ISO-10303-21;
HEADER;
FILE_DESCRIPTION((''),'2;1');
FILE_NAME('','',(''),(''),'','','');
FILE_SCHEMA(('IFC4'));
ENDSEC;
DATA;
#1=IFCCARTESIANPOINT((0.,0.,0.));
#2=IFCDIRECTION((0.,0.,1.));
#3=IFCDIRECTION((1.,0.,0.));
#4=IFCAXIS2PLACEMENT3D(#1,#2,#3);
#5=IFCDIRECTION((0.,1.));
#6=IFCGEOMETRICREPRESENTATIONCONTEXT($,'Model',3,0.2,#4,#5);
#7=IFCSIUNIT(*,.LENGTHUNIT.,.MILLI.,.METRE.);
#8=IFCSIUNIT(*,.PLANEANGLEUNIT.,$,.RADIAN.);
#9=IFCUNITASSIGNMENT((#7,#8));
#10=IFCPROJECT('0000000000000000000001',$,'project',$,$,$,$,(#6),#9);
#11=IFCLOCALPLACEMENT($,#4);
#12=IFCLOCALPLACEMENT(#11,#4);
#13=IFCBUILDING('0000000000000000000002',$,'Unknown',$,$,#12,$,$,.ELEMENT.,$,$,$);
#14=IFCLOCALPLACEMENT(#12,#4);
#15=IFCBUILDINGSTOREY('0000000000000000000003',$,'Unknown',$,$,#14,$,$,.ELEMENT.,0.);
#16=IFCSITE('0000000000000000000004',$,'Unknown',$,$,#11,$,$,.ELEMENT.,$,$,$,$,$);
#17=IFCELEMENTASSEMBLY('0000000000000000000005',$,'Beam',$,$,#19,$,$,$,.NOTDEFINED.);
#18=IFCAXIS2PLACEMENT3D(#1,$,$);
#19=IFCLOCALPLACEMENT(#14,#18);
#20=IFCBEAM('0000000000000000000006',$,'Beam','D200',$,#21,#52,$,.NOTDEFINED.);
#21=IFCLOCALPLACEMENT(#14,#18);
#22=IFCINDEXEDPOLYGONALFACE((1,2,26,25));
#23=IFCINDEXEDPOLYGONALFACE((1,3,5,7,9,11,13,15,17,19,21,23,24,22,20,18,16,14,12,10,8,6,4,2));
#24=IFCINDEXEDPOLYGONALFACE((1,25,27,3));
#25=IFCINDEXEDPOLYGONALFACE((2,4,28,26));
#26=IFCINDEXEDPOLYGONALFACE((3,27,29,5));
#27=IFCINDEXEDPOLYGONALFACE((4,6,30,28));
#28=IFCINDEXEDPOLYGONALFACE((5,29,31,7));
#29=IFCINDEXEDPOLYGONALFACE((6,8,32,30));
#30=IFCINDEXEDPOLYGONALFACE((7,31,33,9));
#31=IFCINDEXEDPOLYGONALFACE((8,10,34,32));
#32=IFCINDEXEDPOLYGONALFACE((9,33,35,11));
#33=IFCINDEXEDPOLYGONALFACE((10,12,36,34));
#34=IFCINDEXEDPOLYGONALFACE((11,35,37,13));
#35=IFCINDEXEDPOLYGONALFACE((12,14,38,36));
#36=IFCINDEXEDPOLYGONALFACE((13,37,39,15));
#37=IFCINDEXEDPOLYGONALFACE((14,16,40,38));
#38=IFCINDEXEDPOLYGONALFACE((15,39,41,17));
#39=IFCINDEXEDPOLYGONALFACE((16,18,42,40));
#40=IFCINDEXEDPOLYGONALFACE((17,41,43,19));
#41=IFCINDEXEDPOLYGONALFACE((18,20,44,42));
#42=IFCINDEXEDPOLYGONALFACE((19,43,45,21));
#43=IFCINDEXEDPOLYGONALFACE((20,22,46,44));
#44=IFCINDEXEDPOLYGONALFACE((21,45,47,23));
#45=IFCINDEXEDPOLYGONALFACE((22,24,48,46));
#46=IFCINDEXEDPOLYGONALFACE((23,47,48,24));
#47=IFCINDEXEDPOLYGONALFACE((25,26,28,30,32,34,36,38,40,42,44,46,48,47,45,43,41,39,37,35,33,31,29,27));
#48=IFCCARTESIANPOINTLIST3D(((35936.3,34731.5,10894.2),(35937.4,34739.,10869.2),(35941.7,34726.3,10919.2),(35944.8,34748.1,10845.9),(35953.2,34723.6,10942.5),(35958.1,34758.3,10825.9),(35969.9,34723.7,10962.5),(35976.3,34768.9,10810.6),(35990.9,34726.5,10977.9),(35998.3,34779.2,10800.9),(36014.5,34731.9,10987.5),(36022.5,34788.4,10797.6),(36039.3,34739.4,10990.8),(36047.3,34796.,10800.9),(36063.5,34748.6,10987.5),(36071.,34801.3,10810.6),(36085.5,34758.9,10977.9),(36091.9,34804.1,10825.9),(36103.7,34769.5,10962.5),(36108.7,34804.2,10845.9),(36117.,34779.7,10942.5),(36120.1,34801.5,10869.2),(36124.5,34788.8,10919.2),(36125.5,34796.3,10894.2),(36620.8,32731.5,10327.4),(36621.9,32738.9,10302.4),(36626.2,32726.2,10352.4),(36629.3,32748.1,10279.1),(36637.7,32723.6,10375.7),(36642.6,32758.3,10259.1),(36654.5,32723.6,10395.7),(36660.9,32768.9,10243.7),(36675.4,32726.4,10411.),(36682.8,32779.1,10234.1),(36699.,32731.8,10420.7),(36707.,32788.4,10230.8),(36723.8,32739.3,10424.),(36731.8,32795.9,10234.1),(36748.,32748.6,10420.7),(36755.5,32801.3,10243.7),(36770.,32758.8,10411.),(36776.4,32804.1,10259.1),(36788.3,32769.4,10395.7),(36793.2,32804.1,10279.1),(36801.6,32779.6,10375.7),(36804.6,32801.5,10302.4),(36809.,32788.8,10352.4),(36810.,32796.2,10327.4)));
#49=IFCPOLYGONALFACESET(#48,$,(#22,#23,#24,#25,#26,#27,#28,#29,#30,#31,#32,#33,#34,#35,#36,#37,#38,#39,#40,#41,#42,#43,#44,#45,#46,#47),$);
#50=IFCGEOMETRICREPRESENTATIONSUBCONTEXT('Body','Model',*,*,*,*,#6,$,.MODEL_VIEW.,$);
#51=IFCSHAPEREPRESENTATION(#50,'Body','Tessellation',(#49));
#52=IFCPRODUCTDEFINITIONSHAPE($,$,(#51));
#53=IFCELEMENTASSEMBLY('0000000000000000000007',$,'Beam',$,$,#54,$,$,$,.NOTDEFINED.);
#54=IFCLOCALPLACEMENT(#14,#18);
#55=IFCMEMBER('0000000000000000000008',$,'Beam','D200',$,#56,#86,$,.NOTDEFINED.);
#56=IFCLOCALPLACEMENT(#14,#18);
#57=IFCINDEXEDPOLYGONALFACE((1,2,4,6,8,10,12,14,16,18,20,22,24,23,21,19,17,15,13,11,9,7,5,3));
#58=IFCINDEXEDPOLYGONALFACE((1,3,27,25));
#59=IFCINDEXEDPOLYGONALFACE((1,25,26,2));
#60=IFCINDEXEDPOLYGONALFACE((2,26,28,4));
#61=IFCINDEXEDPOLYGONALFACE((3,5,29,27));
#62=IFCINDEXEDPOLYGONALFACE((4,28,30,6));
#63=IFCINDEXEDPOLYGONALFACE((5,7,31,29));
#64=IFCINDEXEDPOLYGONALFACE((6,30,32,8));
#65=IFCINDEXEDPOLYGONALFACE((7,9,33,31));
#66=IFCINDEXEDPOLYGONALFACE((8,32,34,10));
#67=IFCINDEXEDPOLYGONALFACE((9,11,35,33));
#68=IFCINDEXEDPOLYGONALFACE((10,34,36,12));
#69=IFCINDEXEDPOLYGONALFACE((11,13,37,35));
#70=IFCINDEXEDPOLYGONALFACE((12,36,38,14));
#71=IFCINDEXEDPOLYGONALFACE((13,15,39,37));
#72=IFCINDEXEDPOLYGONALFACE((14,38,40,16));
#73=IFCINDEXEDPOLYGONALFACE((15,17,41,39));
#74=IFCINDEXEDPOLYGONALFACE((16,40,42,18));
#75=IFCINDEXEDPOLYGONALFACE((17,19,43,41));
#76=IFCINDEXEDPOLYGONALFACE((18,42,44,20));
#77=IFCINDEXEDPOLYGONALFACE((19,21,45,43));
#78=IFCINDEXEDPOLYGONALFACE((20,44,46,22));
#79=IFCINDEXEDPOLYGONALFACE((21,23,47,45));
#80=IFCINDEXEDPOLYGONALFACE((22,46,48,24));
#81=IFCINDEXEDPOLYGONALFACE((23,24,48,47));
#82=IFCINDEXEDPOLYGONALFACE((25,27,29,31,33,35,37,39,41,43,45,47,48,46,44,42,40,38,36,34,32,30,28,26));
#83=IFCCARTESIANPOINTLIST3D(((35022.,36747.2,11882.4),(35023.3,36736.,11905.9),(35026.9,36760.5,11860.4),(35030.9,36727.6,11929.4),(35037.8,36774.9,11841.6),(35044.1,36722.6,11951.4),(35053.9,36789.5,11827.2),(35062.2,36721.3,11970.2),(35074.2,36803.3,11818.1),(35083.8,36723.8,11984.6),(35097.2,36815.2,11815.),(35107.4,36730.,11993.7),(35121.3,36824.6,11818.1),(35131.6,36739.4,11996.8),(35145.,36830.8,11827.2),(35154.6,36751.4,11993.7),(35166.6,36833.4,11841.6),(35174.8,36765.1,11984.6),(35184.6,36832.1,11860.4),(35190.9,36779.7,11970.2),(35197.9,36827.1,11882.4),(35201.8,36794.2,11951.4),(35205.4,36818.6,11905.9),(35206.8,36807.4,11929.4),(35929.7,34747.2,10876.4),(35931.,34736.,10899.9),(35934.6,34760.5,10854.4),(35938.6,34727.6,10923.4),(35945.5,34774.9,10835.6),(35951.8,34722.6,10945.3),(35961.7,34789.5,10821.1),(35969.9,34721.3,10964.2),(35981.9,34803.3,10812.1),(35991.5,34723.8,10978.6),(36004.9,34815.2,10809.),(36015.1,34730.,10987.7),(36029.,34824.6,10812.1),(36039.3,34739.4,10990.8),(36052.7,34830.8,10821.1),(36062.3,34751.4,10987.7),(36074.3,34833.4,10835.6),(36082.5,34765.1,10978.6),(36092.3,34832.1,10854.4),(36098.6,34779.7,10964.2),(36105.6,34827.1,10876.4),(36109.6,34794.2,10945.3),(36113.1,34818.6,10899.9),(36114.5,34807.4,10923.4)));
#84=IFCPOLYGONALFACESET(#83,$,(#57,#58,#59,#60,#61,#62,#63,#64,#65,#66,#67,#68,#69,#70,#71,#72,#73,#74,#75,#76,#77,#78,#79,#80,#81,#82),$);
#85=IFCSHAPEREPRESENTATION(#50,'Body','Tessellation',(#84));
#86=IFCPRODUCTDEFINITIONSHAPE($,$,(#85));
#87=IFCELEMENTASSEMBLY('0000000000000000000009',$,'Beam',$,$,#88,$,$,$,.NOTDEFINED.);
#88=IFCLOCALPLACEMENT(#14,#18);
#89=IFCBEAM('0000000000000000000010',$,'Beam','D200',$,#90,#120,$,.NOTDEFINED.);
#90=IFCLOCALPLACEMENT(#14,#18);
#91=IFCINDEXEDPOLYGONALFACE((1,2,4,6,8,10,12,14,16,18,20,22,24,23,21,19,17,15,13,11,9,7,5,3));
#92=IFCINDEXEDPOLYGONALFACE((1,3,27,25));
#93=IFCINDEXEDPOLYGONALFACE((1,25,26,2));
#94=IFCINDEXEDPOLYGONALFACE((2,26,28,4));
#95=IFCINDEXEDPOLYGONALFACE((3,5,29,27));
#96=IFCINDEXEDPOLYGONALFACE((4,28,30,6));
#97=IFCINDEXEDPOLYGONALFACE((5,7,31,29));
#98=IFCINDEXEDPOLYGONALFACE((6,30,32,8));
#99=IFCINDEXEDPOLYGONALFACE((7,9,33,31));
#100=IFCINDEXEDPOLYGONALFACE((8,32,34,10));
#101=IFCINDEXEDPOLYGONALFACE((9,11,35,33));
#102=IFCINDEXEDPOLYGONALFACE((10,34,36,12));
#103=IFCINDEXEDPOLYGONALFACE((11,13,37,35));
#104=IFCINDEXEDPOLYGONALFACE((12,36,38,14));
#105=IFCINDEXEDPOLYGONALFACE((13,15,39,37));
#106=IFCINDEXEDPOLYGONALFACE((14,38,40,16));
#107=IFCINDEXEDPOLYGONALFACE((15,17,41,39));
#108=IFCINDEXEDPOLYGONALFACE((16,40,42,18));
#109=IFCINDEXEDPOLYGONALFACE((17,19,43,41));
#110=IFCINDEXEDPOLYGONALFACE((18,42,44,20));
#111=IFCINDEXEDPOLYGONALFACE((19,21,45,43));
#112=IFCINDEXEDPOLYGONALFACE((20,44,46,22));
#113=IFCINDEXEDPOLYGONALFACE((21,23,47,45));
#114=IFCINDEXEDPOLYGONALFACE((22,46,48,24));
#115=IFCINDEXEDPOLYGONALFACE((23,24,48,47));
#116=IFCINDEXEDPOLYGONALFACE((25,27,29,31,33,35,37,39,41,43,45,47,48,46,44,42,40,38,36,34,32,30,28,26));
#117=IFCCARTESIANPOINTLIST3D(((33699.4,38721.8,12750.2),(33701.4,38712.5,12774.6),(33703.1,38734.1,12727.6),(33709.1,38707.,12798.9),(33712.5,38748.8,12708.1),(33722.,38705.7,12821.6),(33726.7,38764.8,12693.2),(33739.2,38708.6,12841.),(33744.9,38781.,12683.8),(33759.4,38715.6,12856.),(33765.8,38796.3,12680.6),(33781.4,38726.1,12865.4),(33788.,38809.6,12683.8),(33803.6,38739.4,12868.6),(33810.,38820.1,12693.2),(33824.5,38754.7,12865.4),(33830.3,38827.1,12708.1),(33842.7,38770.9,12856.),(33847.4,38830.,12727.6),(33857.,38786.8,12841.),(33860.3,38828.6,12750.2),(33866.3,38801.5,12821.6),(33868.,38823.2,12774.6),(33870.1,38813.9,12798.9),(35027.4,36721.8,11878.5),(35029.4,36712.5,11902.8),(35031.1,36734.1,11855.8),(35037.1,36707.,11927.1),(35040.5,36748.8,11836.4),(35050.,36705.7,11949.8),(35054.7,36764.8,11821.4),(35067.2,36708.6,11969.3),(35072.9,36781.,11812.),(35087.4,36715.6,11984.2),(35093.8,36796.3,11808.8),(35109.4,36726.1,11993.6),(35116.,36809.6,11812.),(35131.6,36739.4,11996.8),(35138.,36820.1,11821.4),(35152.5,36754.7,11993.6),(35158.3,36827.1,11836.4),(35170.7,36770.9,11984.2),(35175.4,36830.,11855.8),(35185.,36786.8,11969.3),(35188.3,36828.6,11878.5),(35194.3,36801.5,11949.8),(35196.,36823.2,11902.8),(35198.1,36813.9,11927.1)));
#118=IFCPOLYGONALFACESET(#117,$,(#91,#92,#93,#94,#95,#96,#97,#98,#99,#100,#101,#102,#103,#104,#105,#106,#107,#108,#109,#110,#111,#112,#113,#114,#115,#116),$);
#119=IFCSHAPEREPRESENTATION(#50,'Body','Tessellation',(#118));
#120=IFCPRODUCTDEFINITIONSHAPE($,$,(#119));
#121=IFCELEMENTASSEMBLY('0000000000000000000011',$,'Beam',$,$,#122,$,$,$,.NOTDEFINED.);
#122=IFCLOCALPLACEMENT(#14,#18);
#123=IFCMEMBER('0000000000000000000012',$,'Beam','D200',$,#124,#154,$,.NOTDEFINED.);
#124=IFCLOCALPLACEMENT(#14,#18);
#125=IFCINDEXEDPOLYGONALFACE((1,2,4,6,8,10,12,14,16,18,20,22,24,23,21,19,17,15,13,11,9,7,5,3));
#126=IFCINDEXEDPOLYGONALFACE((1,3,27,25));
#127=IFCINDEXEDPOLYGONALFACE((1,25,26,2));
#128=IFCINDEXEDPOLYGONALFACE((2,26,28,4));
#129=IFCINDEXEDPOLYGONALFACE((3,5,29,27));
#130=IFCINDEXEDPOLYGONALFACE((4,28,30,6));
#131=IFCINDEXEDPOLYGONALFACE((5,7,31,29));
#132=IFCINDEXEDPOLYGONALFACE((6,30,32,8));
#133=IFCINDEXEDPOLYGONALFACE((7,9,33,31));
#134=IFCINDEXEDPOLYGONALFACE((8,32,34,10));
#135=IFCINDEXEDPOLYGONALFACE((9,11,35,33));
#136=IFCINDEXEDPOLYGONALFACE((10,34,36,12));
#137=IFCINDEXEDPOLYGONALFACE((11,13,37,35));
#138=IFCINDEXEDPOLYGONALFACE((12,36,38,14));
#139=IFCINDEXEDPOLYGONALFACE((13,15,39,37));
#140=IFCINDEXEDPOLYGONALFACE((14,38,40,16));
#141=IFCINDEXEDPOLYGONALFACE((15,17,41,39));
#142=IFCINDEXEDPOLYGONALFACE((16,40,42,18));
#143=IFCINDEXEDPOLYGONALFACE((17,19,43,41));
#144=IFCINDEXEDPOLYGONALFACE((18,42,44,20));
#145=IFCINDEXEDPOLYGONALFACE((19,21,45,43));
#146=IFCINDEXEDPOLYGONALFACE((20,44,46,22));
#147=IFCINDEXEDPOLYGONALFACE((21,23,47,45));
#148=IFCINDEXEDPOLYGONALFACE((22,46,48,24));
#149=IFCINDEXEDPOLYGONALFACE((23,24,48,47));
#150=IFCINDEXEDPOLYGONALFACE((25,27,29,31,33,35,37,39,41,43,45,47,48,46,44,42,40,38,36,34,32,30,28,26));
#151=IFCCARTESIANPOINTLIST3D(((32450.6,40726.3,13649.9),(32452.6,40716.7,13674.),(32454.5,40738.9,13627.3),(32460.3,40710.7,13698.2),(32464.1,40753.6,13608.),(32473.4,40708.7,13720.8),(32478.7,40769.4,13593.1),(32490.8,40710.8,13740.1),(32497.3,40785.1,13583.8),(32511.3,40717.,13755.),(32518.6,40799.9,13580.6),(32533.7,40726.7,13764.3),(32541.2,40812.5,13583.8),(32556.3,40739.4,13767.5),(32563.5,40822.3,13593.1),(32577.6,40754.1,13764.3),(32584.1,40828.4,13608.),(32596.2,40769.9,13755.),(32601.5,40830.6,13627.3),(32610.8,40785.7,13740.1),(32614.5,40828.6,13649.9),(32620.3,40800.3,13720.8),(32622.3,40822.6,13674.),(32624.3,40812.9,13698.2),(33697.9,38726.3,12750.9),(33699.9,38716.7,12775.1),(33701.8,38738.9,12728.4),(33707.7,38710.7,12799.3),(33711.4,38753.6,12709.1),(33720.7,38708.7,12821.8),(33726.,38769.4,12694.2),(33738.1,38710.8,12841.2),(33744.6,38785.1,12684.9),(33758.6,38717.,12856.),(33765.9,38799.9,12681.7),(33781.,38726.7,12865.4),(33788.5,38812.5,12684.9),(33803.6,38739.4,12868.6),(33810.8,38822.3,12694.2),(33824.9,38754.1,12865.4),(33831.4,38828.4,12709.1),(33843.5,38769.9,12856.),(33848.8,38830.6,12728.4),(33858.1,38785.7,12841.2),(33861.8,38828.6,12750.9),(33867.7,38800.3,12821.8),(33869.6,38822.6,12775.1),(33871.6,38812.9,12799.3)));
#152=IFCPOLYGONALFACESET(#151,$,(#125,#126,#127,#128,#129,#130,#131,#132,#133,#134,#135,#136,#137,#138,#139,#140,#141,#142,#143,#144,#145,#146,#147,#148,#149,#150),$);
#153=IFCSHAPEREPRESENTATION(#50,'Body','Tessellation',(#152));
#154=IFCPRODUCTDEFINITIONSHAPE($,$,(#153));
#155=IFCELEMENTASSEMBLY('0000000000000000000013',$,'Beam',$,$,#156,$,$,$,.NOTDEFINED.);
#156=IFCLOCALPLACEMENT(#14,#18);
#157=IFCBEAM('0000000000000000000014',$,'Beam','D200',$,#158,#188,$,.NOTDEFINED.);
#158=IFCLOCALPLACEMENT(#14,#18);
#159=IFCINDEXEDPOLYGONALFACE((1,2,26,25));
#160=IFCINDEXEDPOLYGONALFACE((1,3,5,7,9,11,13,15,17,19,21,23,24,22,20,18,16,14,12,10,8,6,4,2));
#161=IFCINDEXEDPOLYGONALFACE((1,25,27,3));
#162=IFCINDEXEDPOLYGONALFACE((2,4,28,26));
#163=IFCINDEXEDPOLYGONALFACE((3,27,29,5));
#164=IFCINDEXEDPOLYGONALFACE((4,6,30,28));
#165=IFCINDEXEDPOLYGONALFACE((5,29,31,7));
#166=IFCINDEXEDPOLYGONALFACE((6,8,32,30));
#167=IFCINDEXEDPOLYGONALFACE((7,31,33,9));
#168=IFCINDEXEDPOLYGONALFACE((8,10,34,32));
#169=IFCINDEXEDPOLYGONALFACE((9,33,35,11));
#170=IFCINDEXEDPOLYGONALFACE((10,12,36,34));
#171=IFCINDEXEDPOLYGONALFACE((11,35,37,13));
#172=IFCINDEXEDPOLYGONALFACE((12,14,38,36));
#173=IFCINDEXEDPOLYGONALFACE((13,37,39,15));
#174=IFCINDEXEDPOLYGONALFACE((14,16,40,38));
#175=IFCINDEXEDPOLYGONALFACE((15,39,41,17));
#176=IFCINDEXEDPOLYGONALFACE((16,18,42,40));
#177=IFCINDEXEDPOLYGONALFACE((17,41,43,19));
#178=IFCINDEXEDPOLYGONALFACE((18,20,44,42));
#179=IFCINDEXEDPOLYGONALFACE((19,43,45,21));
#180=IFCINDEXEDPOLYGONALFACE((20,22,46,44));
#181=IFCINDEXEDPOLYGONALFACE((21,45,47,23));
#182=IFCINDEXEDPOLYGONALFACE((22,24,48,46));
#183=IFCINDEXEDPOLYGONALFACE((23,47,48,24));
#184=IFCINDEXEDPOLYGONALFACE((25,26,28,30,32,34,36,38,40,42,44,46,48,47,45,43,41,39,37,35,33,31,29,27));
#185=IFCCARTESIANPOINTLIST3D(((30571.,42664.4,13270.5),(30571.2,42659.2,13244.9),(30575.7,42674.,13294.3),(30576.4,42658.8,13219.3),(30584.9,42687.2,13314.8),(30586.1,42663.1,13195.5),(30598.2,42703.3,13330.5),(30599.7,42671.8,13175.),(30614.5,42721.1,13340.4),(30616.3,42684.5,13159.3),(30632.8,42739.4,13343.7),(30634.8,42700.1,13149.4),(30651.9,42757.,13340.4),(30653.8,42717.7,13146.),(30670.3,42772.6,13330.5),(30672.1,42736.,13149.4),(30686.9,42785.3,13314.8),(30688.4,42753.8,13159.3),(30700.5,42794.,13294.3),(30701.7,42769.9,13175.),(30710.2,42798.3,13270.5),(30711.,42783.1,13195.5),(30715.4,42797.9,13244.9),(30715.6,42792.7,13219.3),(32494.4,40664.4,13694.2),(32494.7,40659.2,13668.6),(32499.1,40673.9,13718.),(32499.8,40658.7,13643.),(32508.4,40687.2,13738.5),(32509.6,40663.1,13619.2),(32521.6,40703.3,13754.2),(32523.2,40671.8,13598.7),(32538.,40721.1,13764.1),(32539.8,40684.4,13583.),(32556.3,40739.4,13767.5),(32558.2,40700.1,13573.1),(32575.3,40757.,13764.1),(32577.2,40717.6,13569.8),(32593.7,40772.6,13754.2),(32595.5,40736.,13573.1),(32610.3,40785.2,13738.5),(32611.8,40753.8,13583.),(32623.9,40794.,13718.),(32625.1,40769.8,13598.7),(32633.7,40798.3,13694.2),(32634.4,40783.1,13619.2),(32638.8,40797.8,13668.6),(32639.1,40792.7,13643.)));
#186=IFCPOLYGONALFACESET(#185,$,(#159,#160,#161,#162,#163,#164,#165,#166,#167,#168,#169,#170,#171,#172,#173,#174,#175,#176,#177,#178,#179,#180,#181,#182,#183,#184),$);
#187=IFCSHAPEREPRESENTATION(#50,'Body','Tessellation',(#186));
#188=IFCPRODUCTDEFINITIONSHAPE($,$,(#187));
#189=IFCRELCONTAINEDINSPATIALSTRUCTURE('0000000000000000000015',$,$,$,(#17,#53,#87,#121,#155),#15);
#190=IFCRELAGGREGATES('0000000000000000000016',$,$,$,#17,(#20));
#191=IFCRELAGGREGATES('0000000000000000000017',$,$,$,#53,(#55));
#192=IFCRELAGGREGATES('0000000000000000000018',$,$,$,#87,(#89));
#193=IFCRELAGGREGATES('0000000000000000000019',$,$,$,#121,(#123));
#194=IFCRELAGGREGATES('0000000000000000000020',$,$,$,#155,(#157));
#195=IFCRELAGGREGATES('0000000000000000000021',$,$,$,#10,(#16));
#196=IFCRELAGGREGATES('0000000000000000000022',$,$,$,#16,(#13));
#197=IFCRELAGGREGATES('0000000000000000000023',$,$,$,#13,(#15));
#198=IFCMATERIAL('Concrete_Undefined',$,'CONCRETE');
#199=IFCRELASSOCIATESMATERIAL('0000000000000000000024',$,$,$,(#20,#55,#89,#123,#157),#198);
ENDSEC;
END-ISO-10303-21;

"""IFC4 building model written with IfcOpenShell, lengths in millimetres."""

from ifc_helpers import new_model, si_unit, direction, frame, origin_with_axes, place, context, subcontext, project, spatial, line, indexed_curve, outline, extrude, material, element, aggregate, save


model = new_model("IFC4")

# Units and contexts
model_context = context("Model", 3, precision=0.2, world=origin_with_axes(), true_north=direction((0.0, 1.0)))
body_context = subcontext(model_context, "Body", "Model", "MODEL_VIEW")
ifc_project = project(units=[si_unit("LENGTHUNIT", "METRE", prefix="MILLI"), si_unit("PLANEANGLEUNIT", "RADIAN")], contexts=[model_context])

# Site, building, storey
site_placement = place(None, origin_with_axes())
site = spatial("IfcSite", under=ifc_project, at=site_placement, Name="Unknown", CompositionType="ELEMENT")
building_placement = place(site_placement, origin_with_axes())
building = spatial("IfcBuilding", under=site, at=building_placement, Name="Unknown", CompositionType="ELEMENT")
storey_placement = place(building_placement, origin_with_axes())
storey = spatial("IfcBuildingStorey", under=building, at=storey_placement, Name="Unknown", CompositionType="ELEMENT", Elevation=0.0)

# Shared definitions
ifc_material = material(Name="Concrete_Undefined", Category="CONCRETE")

# Element assembly, beam
assembly_1_placement = place(storey_placement, frame((36030.9, 34763.9, 10894.2), z_axis=(-0.946122, -0.32381, 0.0), x_axis=(0.312762, -0.913841, -0.258986)))
assembly_1 = element("IfcElementAssembly", 1, at=assembly_1_placement, inside=storey, Name="Beam", PredefinedType="NOTDEFINED")
beam_1_placement = place(assembly_1_placement, origin_with_axes())
beam_1 = element("IfcBeam", 2, at=beam_1_placement, material=ifc_material, Name="Beam", Description="D200", PredefinedType="NOTDEFINED", context=body_context, shape_type="SolidModel", body=[
    extrude(outline(indexed_curve([(100.0, 0.0), (96.6, 25.9), (86.6, 50.0), (70.7, 70.7), (50.0, 86.6), (25.9, 96.6), (0.0, 100.0), (-25.9, 96.6), (-50.0, 86.6), (-70.7, 70.7), (-86.6, 50.0), (-96.6, 25.9), (-100.0, 0.0), (-96.6, -25.9), (-86.6, -50.0), (-70.7, -70.7), (-50.0, -86.6), (-25.9, -96.6), (0.0, -100.0), (25.9, -96.6), (50.0, -86.6), (70.7, -70.7), (86.6, -50.0), (96.6, -25.9)], segments=[line(1, 2, 3, 4, 5, 6, 7, 8, 9, 10, 11, 12, 13, 14, 15, 16, 17, 18, 19, 20, 21, 22, 23, 24, 1)])), frame((0.0, 0.0, 0.0), z_axis=(-1.0, 0.0, 0.0), x_axis=(0.0, 0.0, 1.0)), (0.0, 0.0, -1.0), 2188.6),
])
aggregate(assembly_1, [beam_1])

# Element assembly, member
assembly_2_placement = place(storey_placement, frame((35114.4, 36777.3, 11905.9), z_axis=(-0.910603, -0.413282, 0.0), x_axis=(0.375742, -0.82789, -0.416432)))
assembly_2 = element("IfcElementAssembly", 3, at=assembly_2_placement, inside=storey, Name="Beam", PredefinedType="NOTDEFINED")
member_1_placement = place(assembly_2_placement, origin_with_axes())
member_1 = element("IfcMember", 4, at=member_1_placement, material=ifc_material, Name="Beam", Description="D200", PredefinedType="NOTDEFINED", context=body_context, shape_type="SolidModel", body=[
    extrude(outline(indexed_curve([(100.0, 0.0), (96.6, 25.9), (86.6, 50.0), (70.7, 70.7), (50.0, 86.6), (25.9, 96.6), (0.0, 100.0), (-25.9, 96.6), (-50.0, 86.6), (-70.7, 70.7), (-86.6, 50.0), (-96.6, 25.9), (-100.0, 0.0), (-96.6, -25.9), (-86.6, -50.0), (-70.7, -70.7), (-50.0, -86.6), (-25.9, -96.6), (0.0, -100.0), (25.9, -96.6), (50.0, -86.6), (70.7, -70.7), (86.6, -50.0), (96.6, -25.9)], segments=[line(1, 2, 3, 4, 5, 6, 7, 8, 9, 10, 11, 12, 13, 14, 15, 16, 17, 18, 19, 20, 21, 22, 23, 24, 1)])), frame((0.0, 0.0, 0.0), z_axis=(-1.0, 0.0, 0.0), x_axis=(0.0, 0.0, 1.0)), (0.0, 0.0, -1.0), 2415.8),
])
aggregate(assembly_2, [member_1])

# Element assembly, beam
assembly_3_placement = place(storey_placement, frame((33784.7, 38767.8, 12774.6), z_axis=(-0.833076, -0.553159, 0.0), x_axis=(0.519942, -0.78305, -0.34131)))
assembly_3 = element("IfcElementAssembly", 5, at=assembly_3_placement, inside=storey, Name="Beam", PredefinedType="NOTDEFINED")
beam_2_placement = place(assembly_3_placement, origin_with_axes())
beam_2 = element("IfcBeam", 6, at=beam_2_placement, material=ifc_material, Name="Beam", Description="D200", PredefinedType="NOTDEFINED", context=body_context, shape_type="SolidModel", body=[
    extrude(outline(indexed_curve([(100.0, 0.0), (96.6, 25.9), (86.6, 50.0), (70.7, 70.7), (50.0, 86.6), (25.9, 96.6), (0.0, 100.0), (-25.9, 96.6), (-50.0, 86.6), (-70.7, 70.7), (-86.6, 50.0), (-96.6, 25.9), (-100.0, 0.0), (-96.6, -25.9), (-86.6, -50.0), (-70.7, -70.7), (-50.0, -86.6), (-25.9, -96.6), (0.0, -100.0), (25.9, -96.6), (50.0, -86.6), (70.7, -70.7), (86.6, -50.0), (96.6, -25.9)], segments=[line(1, 2, 3, 4, 5, 6, 7, 8, 9, 10, 11, 12, 13, 14, 15, 16, 17, 18, 19, 20, 21, 22, 23, 24, 1)])), frame((0.0, 0.0, 0.0), z_axis=(-1.0, 0.0, 0.0), x_axis=(0.0, 0.0, 1.0)), (0.0, 0.0, -1.0), 2554.1),
])
aggregate(assembly_3, [beam_2])

# Element assembly, member
assembly_4_placement = place(storey_placement, frame((32537.4, 40769.6, 13674.0), z_axis=(-0.84851, -0.529179, 0.0), x_axis=(0.494442, -0.792812, -0.356337)))
assembly_4 = element("IfcElementAssembly", 7, at=assembly_4_placement, inside=storey, Name="Beam", PredefinedType="NOTDEFINED")
member_2_placement = place(assembly_4_placement, origin_with_axes())
member_2 = element("IfcMember", 8, at=member_2_placement, material=ifc_material, Name="Beam", Description="D200", PredefinedType="NOTDEFINED", context=body_context, shape_type="SolidModel", body=[
    extrude(outline(indexed_curve([(100.0, 0.0), (96.6, 25.9), (86.6, 50.0), (70.7, 70.7), (50.0, 86.6), (25.9, 96.6), (0.0, 100.0), (-25.9, 96.6), (-50.0, 86.6), (-70.7, 70.7), (-86.6, 50.0), (-96.6, 25.9), (-100.0, 0.0), (-96.6, -25.9), (-86.6, -50.0), (-70.7, -70.7), (-50.0, -86.6), (-25.9, -96.6), (0.0, -100.0), (25.9, -96.6), (50.0, -86.6), (70.7, -70.7), (86.6, -50.0), (96.6, -25.9)], segments=[line(1, 2, 3, 4, 5, 6, 7, 8, 9, 10, 11, 12, 13, 14, 15, 16, 17, 18, 19, 20, 21, 22, 23, 24, 1)])), frame((0.0, 0.0, 0.0), z_axis=(-1.0, 0.0, 0.0), x_axis=(0.0, 0.0, 1.0)), (0.0, 0.0, -1.0), 2522.7),
])
aggregate(assembly_4, [member_2])

# Element assembly, beam
assembly_5_placement = place(storey_placement, frame((30643.3, 42728.5, 13244.9), z_axis=(-0.720771, -0.693173, 0.0), x_axis=(0.685229, -0.712511, 0.150959)))
assembly_5 = element("IfcElementAssembly", 9, at=assembly_5_placement, inside=storey, Name="Beam", PredefinedType="NOTDEFINED")
beam_3_placement = place(assembly_5_placement, origin_with_axes())
beam_3 = element("IfcBeam", 10, at=beam_3_placement, material=ifc_material, Name="Beam", Description="D200", PredefinedType="NOTDEFINED", context=body_context, shape_type="SolidModel", body=[
    extrude(outline(indexed_curve([(100.0, 0.0), (96.6, 25.9), (86.6, 50.0), (70.7, 70.7), (50.0, 86.6), (25.9, 96.6), (0.0, 100.0), (-25.9, 96.6), (-50.0, 86.6), (-70.7, 70.7), (-86.6, 50.0), (-96.6, 25.9), (-100.0, 0.0), (-96.6, -25.9), (-86.6, -50.0), (-70.7, -70.7), (-50.0, -86.6), (-25.9, -96.6), (0.0, -100.0), (25.9, -96.6), (50.0, -86.6), (70.7, -70.7), (86.6, -50.0), (96.6, -25.9)], segments=[line(1, 2, 3, 4, 5, 6, 7, 8, 9, 10, 11, 12, 13, 14, 15, 16, 17, 18, 19, 20, 21, 22, 23, 24, 1)])), frame((0.0, 0.0, 0.0), z_axis=(-1.0, 0.0, 0.0), x_axis=(0.0, 0.0, 1.0)), (0.0, 0.0, -1.0), 2807.0),
])
aggregate(assembly_5, [beam_3])

save(model, "model.ifc")
